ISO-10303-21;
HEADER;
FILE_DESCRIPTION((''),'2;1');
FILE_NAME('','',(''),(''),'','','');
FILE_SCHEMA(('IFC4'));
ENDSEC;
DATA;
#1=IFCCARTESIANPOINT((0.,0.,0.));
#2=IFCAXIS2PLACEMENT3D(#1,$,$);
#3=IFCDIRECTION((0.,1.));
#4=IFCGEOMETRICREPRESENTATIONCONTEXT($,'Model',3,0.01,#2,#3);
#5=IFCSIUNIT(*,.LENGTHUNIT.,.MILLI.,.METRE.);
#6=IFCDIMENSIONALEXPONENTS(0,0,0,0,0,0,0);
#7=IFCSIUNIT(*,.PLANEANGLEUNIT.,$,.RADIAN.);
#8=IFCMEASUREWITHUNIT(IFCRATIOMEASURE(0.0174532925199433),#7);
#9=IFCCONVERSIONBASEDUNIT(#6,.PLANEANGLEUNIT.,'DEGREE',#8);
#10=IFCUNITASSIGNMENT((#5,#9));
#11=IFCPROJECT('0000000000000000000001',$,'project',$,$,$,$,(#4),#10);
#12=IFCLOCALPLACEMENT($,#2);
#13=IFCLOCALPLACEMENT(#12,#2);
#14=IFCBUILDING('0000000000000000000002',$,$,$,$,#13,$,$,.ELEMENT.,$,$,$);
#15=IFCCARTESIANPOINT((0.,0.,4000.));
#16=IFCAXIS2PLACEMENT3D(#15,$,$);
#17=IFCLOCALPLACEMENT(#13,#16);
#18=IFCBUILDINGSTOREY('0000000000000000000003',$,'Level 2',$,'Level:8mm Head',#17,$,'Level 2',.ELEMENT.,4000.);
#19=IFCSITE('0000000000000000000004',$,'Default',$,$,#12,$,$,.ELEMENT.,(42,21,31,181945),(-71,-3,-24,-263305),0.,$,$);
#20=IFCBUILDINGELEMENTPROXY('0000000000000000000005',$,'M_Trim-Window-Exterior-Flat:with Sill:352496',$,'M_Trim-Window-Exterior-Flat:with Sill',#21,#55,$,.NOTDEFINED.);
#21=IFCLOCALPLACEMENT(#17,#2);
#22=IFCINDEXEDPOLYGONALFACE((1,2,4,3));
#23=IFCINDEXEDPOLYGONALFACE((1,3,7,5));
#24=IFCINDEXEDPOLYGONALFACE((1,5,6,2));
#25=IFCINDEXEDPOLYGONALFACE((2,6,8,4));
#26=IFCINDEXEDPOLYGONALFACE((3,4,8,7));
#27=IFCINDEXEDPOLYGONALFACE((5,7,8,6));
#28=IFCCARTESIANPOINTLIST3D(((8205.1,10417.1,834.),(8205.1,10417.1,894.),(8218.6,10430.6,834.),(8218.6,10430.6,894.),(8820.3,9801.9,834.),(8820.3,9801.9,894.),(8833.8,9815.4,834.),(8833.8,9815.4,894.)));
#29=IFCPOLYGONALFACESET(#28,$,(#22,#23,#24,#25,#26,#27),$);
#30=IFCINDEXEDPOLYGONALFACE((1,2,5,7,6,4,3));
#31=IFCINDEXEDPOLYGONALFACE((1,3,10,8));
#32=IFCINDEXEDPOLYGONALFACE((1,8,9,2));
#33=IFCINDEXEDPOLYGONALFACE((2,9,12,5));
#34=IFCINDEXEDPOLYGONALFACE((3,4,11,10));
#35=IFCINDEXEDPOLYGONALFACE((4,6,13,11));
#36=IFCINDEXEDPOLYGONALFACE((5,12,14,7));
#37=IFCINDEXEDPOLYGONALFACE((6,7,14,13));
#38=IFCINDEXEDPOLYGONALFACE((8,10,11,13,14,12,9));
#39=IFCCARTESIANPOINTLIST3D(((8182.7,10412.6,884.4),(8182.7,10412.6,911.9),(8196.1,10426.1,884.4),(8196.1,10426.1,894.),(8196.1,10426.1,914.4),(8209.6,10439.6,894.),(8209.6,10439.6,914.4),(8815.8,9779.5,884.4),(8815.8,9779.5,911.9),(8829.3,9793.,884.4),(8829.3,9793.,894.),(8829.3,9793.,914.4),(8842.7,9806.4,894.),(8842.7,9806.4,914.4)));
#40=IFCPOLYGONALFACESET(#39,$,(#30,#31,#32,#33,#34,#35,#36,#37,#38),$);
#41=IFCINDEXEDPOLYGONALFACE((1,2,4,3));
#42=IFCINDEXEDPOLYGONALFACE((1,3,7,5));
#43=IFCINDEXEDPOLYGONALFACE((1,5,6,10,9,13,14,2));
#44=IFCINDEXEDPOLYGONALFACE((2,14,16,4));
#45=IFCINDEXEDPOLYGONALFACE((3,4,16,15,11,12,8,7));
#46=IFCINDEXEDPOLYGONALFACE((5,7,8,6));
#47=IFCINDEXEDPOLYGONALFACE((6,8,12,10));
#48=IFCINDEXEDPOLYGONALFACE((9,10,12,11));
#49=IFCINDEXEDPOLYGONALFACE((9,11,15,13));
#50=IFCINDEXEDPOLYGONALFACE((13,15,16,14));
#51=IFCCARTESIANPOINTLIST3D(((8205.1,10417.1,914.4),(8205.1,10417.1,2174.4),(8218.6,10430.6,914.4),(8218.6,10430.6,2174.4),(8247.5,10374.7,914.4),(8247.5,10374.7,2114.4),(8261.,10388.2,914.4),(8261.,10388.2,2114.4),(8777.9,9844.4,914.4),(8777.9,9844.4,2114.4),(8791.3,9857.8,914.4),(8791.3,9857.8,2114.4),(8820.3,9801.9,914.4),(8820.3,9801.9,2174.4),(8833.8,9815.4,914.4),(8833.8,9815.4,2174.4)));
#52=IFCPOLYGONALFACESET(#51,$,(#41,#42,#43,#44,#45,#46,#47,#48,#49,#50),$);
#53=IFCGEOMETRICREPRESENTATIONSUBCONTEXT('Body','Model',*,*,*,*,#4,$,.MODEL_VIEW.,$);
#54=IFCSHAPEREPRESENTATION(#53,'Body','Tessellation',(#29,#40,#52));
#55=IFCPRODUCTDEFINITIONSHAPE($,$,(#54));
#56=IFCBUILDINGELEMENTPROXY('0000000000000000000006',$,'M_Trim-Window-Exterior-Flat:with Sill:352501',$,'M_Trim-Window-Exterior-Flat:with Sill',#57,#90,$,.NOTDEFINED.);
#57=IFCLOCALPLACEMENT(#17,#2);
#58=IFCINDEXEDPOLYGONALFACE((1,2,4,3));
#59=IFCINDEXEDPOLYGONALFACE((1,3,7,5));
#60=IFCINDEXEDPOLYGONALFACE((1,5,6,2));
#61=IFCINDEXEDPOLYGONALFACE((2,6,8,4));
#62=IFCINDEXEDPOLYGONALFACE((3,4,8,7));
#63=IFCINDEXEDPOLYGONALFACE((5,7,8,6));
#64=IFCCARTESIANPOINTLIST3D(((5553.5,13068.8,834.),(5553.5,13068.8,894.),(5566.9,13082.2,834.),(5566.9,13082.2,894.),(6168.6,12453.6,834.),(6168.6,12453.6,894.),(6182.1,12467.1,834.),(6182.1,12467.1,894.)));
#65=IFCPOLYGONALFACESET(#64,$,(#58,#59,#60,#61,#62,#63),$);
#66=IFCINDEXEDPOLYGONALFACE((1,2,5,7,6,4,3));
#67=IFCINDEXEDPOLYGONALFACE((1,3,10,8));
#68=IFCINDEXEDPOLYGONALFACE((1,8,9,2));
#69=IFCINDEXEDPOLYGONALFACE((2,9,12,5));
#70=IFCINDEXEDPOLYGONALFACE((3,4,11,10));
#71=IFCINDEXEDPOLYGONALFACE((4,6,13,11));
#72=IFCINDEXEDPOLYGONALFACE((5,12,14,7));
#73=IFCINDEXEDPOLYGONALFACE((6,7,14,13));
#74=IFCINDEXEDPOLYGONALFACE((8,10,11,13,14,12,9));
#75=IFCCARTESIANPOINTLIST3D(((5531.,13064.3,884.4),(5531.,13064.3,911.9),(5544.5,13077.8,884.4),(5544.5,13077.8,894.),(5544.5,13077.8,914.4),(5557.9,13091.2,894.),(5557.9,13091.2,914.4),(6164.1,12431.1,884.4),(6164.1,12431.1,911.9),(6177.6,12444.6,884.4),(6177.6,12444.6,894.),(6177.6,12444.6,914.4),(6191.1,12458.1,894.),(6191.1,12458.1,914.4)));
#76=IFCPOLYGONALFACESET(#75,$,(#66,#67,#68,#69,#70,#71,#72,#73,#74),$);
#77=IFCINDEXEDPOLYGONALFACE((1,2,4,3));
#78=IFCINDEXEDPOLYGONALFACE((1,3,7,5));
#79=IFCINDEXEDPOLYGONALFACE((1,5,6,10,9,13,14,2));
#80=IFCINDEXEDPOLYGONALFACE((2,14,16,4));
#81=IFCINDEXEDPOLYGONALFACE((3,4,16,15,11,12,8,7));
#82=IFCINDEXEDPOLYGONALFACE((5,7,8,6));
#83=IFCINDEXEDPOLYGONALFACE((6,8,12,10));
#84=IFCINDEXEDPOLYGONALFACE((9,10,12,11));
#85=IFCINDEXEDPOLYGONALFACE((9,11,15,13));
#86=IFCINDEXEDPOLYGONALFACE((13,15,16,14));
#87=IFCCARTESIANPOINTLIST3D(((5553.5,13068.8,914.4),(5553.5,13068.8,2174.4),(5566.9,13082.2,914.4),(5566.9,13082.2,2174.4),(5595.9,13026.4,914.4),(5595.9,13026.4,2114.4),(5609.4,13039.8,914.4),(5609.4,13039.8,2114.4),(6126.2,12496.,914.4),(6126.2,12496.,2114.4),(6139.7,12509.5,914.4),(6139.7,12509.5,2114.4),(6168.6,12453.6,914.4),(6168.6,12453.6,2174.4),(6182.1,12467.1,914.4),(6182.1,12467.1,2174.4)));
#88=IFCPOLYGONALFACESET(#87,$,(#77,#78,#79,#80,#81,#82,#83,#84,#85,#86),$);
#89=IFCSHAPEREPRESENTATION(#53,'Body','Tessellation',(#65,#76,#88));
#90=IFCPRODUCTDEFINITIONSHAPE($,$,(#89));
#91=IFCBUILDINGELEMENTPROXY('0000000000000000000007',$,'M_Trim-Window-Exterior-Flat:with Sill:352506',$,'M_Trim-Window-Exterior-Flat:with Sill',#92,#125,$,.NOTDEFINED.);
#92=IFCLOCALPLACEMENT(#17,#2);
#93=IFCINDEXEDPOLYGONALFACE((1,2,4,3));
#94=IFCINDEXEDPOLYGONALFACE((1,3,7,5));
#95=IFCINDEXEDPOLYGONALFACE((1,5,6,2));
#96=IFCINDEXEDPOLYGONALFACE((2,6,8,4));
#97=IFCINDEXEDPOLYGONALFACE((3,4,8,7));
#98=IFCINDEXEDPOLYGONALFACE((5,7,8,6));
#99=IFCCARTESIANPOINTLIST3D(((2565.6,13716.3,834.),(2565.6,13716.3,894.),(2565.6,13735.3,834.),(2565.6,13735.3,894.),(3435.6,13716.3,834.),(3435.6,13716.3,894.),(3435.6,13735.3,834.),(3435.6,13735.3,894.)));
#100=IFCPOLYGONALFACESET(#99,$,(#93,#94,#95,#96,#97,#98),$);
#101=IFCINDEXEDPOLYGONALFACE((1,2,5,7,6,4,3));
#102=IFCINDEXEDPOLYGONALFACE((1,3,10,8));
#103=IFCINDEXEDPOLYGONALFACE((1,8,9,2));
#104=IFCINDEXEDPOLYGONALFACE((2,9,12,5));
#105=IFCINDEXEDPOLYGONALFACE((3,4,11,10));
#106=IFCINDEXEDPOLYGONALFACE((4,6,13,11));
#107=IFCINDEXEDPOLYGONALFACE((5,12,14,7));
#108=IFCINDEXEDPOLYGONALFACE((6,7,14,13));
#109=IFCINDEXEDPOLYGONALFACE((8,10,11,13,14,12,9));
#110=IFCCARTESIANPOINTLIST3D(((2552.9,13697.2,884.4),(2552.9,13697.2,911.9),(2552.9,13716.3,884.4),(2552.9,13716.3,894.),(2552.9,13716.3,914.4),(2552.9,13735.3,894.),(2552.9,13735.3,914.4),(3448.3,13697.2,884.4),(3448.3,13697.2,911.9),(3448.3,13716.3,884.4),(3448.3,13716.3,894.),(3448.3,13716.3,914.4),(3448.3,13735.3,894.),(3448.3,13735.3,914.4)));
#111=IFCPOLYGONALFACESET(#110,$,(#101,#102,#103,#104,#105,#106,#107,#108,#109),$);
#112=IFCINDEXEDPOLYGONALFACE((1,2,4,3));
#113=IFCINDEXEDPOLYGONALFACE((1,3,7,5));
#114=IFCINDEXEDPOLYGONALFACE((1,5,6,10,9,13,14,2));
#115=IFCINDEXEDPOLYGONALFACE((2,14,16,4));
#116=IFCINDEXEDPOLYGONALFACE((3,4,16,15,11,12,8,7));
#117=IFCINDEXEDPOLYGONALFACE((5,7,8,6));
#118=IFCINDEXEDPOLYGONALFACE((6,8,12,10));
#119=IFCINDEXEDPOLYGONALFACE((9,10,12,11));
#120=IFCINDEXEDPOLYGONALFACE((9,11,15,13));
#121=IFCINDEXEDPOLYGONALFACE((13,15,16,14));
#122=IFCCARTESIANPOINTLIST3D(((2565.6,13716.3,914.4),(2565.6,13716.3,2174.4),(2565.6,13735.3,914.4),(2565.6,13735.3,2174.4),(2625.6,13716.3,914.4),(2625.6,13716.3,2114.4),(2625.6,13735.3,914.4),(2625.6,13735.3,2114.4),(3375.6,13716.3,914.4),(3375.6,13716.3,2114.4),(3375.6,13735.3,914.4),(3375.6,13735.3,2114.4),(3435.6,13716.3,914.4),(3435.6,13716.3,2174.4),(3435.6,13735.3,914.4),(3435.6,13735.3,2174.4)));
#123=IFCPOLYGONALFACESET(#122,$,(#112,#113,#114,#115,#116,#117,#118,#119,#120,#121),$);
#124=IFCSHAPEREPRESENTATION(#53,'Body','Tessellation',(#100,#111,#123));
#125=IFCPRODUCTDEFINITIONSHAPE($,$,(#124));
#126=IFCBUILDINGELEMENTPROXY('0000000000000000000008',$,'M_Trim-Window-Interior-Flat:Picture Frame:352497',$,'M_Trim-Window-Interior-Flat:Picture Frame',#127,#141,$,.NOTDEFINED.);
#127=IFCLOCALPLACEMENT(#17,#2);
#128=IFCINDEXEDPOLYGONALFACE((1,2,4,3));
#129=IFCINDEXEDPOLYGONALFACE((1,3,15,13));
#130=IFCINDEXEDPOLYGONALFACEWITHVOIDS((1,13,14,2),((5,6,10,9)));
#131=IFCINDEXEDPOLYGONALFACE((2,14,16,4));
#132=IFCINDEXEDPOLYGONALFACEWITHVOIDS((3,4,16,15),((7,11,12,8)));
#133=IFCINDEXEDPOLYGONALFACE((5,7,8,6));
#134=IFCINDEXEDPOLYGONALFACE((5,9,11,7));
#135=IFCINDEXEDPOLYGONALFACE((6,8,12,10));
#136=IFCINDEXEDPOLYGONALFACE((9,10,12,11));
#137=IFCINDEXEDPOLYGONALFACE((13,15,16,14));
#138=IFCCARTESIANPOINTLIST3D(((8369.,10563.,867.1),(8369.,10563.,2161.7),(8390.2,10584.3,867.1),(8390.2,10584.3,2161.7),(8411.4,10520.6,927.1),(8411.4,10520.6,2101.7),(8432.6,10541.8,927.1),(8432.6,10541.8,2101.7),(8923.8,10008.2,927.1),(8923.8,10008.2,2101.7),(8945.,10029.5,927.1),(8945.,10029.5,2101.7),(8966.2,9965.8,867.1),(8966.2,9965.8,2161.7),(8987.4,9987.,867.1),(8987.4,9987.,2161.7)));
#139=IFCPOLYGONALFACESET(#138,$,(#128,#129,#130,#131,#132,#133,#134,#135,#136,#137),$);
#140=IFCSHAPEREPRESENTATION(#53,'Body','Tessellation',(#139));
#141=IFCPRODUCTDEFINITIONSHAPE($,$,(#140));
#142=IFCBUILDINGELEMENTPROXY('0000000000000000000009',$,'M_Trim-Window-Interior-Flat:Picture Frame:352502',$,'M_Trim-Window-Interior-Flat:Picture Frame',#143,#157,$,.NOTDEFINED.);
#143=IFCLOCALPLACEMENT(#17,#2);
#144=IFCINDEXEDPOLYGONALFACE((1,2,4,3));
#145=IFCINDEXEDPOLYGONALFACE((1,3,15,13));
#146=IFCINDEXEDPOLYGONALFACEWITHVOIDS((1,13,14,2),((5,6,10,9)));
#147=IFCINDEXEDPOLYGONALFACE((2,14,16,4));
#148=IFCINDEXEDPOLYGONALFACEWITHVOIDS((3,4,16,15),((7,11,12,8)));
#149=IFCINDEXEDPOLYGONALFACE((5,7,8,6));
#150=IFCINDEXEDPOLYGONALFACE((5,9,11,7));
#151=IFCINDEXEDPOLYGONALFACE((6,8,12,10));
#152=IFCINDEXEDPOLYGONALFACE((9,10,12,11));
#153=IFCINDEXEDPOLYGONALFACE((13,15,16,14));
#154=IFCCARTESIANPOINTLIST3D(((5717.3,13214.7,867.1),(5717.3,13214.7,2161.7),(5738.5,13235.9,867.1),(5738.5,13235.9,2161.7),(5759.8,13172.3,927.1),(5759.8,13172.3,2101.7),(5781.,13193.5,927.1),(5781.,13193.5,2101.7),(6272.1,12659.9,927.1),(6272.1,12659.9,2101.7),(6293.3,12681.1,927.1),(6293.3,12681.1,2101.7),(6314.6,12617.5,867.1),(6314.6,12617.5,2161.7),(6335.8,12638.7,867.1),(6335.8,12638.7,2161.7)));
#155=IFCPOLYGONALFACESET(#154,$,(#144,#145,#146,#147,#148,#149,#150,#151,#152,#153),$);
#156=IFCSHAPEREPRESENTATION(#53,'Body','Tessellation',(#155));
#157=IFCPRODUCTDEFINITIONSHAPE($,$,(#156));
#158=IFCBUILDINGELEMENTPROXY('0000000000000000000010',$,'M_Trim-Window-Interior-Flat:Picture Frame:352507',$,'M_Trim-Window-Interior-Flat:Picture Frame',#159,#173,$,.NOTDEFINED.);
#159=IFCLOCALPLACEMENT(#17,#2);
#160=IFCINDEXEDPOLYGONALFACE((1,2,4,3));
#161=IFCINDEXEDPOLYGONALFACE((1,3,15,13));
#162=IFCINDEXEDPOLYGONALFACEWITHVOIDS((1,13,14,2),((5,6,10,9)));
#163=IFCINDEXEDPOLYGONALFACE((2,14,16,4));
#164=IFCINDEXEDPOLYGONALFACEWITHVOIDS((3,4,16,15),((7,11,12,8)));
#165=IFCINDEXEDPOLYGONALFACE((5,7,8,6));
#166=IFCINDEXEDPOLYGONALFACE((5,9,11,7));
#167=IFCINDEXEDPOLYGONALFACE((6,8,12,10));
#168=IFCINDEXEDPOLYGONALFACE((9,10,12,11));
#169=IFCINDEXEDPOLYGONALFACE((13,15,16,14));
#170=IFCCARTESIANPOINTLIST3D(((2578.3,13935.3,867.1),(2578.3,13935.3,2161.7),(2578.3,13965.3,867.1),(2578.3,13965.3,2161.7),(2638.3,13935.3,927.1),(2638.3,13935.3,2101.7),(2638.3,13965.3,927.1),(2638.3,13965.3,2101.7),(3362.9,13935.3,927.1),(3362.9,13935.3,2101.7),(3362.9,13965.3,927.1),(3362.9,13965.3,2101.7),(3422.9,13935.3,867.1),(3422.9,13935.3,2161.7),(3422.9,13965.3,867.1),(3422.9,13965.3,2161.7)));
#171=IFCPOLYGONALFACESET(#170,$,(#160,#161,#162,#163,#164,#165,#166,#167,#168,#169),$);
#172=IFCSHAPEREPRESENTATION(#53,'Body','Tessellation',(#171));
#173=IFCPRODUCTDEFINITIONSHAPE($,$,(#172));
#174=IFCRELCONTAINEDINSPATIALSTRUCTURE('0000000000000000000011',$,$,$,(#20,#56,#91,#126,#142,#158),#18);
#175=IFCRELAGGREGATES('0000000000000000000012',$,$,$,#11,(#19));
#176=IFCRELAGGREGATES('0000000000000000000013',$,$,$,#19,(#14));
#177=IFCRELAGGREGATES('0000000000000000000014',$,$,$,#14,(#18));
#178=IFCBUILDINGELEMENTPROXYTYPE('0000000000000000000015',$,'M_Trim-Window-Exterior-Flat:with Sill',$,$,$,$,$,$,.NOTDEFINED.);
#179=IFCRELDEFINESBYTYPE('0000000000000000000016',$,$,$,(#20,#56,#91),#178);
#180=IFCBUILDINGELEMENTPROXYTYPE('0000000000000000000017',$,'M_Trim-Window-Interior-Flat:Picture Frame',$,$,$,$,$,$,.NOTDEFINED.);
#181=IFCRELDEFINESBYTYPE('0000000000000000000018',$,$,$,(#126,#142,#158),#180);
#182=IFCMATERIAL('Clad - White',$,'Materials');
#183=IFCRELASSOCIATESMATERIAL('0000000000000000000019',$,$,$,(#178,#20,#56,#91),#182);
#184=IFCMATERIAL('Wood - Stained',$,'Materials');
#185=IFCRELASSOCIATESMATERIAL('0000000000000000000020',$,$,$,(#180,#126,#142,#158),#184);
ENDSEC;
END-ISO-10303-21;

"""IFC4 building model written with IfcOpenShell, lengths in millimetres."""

from ifc_helpers import new_model, entity, si_unit, converted_unit, direction, frame, frame_2d, origin, place, context, subcontext, project, spatial, polyline, rectangle, outline, extrude, source, transform, mapped, material, type_object, type_shapes, element, save


model = new_model("IFC4")

# Units and contexts
model_context = context("Model", 3, precision=0.01, world=origin(), true_north=direction((0.0, 1.0)))
body_context = subcontext(model_context, "Body", "Model", "MODEL_VIEW")
ifc_project = project(units=[si_unit("LENGTHUNIT", "METRE", prefix="MILLI"), converted_unit("PLANEANGLEUNIT", "DEGREE", entity("IfcRatioMeasure", 0.0174532925199433), si_unit("PLANEANGLEUNIT", "RADIAN"), dimensions=[0, 0, 0, 0, 0, 0, 0])], contexts=[model_context])

# Site, building, storey
site_placement = place(None, origin())
site = spatial("IfcSite", under=ifc_project, at=site_placement, Name="Default", CompositionType="ELEMENT", RefLatitude=(42, 21, 31, 181945), RefLongitude=(-71, -3, -24, -263305), RefElevation=0.0)
building_placement = place(site_placement, origin())
building = spatial("IfcBuilding", under=site, at=building_placement, CompositionType="ELEMENT")
storey_placement = place(building_placement, frame((0.0, 0.0, 4000.0)))
storey = spatial("IfcBuildingStorey", under=building, at=storey_placement, Name="Level 2", ObjectType="Level:8mm Head", LongName="Level 2", CompositionType="ELEMENT", Elevation=4000.0)

# Shared definitions
ifc_material_1 = material(Name="Wood - Stained", Category="Materials")

# Building element proxies
ifc_material_2 = material(Name="Clad - White", Category="Materials")
building_element_proxy_type_1 = type_object("IfcBuildingElementProxyType", Name="M_Trim-Window-Exterior-Flat:with Sill", PredefinedType="NOTDEFINED", material=ifc_material_2)
shared_shape_1 = source(origin(), body_context, "Body", "SweptSolid", [
    extrude(rectangle(XDim=870.0, YDim=60.0, at=frame_2d((0.0, 0.0), x_axis=(1.0, 0.0))), frame((0.0, -1250.4, 0.0), z_axis=(0.0, 0.0, 1.0), x_axis=(-1.0, 0.0, 0.0)), (0.0, 0.0, 1.0), 19.1),
    extrude(outline(polyline([(-19.0, -15.2), (0.0, -15.2), (0.0, -5.7), (19.0, -5.7), (19.0, 14.8), (0.0, 14.8), (-19.0, 12.3), (-19.0, -15.2)])), frame((-447.7, -1214.8, 19.0), z_axis=(1.0, 0.0, 0.0), x_axis=(0.0, 0.0, -1.0)), (0.0, 0.0, 1.0), 895.4),
    extrude(outline(polyline([(-645.0, -435.0), (615.0, -435.0), (615.0, -375.0), (-585.0, -375.0), (-585.0, 375.0), (615.0, 375.0), (615.0, 435.0), (-645.0, 435.0), (-645.0, -435.0)])), frame((0.0, -585.0, 0.0), z_axis=(0.0, 0.0, 1.0), x_axis=(0.0, -1.0, 0.0)), (0.0, 0.0, 1.0), 19.1),
])
type_shapes(building_element_proxy_type_1, [shared_shape_1])
for number, where, z_axis, x_axis, name in (
    (1, (8526.2, 10123.0, 2114.4), (-0.707107, -0.707107, 0.0), (0.707107, -0.707107, 0.0), "M_Trim-Window-Exterior-Flat:with Sill:352496"),
    (2, (5874.5, 12774.7, 2114.4), (-0.707107, -0.707107, 0.0), (0.707107, -0.707107, 0.0), "M_Trim-Window-Exterior-Flat:with Sill:352501"),
    (3, (3000.6, 13735.3, 2114.4), (0.0, -1.0, 0.0), (1.0, 0.0, 0.0), "M_Trim-Window-Exterior-Flat:with Sill:352506"),
):
    element("IfcBuildingElementProxy", number, at=place(storey_placement, frame(where, z_axis=z_axis, x_axis=x_axis)), inside=storey, type_object=building_element_proxy_type_1, material=ifc_material_2, Name=name, ObjectType="M_Trim-Window-Exterior-Flat:with Sill", PredefinedType="NOTDEFINED", context=body_context, shape_type="MappedRepresentation", body=[
        mapped(shared_shape_1, transform((0.0, 0.0, 0.0), scale=1.0)),
    ])
building_element_proxy_type_2 = type_object("IfcBuildingElementProxyType", Name="M_Trim-Window-Interior-Flat:Picture Frame", PredefinedType="NOTDEFINED", material=ifc_material_1)
shared_shape_2 = source(origin(), body_context, "Body", "SweptSolid", [
    extrude(outline(polyline([(-422.3, -647.3), (422.3, -647.3), (422.3, 647.3), (-422.3, 647.3), (-422.3, -647.3)]), holes=[polyline([(-362.3, -587.3), (-362.3, 587.3), (362.3, 587.3), (362.3, -587.3), (-362.3, -587.3)])]), frame((0.0, -600.0, 0.0), z_axis=(0.0, 0.0, 1.0), x_axis=(-1.0, 0.0, 0.0)), (0.0, 0.0, 1.0), 30.0),
])
type_shapes(building_element_proxy_type_2, [shared_shape_2])
for number, where, z_axis, x_axis, name in (
    (4, (8667.6, 10264.4, 2114.4), (0.707107, 0.707107, 0.0), (-0.707107, 0.707107, 0.0), "M_Trim-Window-Interior-Flat:Picture Frame:352497"),
    (5, (6015.9, 12916.1, 2114.4), (0.707107, 0.707107, 0.0), (-0.707107, 0.707107, 0.0), "M_Trim-Window-Interior-Flat:Picture Frame:352502"),
    (6, (3000.6, 13935.3, 2114.4), (0.0, 1.0, 0.0), (-1.0, 0.0, 0.0), "M_Trim-Window-Interior-Flat:Picture Frame:352507"),
):
    element("IfcBuildingElementProxy", number, at=place(storey_placement, frame(where, z_axis=z_axis, x_axis=x_axis)), inside=storey, type_object=building_element_proxy_type_2, material=ifc_material_1, Name=name, ObjectType="M_Trim-Window-Interior-Flat:Picture Frame", PredefinedType="NOTDEFINED", context=body_context, shape_type="MappedRepresentation", body=[
        mapped(shared_shape_2, transform((0.0, 0.0, 0.0), scale=1.0)),
    ])

save(model, "model.ifc")
